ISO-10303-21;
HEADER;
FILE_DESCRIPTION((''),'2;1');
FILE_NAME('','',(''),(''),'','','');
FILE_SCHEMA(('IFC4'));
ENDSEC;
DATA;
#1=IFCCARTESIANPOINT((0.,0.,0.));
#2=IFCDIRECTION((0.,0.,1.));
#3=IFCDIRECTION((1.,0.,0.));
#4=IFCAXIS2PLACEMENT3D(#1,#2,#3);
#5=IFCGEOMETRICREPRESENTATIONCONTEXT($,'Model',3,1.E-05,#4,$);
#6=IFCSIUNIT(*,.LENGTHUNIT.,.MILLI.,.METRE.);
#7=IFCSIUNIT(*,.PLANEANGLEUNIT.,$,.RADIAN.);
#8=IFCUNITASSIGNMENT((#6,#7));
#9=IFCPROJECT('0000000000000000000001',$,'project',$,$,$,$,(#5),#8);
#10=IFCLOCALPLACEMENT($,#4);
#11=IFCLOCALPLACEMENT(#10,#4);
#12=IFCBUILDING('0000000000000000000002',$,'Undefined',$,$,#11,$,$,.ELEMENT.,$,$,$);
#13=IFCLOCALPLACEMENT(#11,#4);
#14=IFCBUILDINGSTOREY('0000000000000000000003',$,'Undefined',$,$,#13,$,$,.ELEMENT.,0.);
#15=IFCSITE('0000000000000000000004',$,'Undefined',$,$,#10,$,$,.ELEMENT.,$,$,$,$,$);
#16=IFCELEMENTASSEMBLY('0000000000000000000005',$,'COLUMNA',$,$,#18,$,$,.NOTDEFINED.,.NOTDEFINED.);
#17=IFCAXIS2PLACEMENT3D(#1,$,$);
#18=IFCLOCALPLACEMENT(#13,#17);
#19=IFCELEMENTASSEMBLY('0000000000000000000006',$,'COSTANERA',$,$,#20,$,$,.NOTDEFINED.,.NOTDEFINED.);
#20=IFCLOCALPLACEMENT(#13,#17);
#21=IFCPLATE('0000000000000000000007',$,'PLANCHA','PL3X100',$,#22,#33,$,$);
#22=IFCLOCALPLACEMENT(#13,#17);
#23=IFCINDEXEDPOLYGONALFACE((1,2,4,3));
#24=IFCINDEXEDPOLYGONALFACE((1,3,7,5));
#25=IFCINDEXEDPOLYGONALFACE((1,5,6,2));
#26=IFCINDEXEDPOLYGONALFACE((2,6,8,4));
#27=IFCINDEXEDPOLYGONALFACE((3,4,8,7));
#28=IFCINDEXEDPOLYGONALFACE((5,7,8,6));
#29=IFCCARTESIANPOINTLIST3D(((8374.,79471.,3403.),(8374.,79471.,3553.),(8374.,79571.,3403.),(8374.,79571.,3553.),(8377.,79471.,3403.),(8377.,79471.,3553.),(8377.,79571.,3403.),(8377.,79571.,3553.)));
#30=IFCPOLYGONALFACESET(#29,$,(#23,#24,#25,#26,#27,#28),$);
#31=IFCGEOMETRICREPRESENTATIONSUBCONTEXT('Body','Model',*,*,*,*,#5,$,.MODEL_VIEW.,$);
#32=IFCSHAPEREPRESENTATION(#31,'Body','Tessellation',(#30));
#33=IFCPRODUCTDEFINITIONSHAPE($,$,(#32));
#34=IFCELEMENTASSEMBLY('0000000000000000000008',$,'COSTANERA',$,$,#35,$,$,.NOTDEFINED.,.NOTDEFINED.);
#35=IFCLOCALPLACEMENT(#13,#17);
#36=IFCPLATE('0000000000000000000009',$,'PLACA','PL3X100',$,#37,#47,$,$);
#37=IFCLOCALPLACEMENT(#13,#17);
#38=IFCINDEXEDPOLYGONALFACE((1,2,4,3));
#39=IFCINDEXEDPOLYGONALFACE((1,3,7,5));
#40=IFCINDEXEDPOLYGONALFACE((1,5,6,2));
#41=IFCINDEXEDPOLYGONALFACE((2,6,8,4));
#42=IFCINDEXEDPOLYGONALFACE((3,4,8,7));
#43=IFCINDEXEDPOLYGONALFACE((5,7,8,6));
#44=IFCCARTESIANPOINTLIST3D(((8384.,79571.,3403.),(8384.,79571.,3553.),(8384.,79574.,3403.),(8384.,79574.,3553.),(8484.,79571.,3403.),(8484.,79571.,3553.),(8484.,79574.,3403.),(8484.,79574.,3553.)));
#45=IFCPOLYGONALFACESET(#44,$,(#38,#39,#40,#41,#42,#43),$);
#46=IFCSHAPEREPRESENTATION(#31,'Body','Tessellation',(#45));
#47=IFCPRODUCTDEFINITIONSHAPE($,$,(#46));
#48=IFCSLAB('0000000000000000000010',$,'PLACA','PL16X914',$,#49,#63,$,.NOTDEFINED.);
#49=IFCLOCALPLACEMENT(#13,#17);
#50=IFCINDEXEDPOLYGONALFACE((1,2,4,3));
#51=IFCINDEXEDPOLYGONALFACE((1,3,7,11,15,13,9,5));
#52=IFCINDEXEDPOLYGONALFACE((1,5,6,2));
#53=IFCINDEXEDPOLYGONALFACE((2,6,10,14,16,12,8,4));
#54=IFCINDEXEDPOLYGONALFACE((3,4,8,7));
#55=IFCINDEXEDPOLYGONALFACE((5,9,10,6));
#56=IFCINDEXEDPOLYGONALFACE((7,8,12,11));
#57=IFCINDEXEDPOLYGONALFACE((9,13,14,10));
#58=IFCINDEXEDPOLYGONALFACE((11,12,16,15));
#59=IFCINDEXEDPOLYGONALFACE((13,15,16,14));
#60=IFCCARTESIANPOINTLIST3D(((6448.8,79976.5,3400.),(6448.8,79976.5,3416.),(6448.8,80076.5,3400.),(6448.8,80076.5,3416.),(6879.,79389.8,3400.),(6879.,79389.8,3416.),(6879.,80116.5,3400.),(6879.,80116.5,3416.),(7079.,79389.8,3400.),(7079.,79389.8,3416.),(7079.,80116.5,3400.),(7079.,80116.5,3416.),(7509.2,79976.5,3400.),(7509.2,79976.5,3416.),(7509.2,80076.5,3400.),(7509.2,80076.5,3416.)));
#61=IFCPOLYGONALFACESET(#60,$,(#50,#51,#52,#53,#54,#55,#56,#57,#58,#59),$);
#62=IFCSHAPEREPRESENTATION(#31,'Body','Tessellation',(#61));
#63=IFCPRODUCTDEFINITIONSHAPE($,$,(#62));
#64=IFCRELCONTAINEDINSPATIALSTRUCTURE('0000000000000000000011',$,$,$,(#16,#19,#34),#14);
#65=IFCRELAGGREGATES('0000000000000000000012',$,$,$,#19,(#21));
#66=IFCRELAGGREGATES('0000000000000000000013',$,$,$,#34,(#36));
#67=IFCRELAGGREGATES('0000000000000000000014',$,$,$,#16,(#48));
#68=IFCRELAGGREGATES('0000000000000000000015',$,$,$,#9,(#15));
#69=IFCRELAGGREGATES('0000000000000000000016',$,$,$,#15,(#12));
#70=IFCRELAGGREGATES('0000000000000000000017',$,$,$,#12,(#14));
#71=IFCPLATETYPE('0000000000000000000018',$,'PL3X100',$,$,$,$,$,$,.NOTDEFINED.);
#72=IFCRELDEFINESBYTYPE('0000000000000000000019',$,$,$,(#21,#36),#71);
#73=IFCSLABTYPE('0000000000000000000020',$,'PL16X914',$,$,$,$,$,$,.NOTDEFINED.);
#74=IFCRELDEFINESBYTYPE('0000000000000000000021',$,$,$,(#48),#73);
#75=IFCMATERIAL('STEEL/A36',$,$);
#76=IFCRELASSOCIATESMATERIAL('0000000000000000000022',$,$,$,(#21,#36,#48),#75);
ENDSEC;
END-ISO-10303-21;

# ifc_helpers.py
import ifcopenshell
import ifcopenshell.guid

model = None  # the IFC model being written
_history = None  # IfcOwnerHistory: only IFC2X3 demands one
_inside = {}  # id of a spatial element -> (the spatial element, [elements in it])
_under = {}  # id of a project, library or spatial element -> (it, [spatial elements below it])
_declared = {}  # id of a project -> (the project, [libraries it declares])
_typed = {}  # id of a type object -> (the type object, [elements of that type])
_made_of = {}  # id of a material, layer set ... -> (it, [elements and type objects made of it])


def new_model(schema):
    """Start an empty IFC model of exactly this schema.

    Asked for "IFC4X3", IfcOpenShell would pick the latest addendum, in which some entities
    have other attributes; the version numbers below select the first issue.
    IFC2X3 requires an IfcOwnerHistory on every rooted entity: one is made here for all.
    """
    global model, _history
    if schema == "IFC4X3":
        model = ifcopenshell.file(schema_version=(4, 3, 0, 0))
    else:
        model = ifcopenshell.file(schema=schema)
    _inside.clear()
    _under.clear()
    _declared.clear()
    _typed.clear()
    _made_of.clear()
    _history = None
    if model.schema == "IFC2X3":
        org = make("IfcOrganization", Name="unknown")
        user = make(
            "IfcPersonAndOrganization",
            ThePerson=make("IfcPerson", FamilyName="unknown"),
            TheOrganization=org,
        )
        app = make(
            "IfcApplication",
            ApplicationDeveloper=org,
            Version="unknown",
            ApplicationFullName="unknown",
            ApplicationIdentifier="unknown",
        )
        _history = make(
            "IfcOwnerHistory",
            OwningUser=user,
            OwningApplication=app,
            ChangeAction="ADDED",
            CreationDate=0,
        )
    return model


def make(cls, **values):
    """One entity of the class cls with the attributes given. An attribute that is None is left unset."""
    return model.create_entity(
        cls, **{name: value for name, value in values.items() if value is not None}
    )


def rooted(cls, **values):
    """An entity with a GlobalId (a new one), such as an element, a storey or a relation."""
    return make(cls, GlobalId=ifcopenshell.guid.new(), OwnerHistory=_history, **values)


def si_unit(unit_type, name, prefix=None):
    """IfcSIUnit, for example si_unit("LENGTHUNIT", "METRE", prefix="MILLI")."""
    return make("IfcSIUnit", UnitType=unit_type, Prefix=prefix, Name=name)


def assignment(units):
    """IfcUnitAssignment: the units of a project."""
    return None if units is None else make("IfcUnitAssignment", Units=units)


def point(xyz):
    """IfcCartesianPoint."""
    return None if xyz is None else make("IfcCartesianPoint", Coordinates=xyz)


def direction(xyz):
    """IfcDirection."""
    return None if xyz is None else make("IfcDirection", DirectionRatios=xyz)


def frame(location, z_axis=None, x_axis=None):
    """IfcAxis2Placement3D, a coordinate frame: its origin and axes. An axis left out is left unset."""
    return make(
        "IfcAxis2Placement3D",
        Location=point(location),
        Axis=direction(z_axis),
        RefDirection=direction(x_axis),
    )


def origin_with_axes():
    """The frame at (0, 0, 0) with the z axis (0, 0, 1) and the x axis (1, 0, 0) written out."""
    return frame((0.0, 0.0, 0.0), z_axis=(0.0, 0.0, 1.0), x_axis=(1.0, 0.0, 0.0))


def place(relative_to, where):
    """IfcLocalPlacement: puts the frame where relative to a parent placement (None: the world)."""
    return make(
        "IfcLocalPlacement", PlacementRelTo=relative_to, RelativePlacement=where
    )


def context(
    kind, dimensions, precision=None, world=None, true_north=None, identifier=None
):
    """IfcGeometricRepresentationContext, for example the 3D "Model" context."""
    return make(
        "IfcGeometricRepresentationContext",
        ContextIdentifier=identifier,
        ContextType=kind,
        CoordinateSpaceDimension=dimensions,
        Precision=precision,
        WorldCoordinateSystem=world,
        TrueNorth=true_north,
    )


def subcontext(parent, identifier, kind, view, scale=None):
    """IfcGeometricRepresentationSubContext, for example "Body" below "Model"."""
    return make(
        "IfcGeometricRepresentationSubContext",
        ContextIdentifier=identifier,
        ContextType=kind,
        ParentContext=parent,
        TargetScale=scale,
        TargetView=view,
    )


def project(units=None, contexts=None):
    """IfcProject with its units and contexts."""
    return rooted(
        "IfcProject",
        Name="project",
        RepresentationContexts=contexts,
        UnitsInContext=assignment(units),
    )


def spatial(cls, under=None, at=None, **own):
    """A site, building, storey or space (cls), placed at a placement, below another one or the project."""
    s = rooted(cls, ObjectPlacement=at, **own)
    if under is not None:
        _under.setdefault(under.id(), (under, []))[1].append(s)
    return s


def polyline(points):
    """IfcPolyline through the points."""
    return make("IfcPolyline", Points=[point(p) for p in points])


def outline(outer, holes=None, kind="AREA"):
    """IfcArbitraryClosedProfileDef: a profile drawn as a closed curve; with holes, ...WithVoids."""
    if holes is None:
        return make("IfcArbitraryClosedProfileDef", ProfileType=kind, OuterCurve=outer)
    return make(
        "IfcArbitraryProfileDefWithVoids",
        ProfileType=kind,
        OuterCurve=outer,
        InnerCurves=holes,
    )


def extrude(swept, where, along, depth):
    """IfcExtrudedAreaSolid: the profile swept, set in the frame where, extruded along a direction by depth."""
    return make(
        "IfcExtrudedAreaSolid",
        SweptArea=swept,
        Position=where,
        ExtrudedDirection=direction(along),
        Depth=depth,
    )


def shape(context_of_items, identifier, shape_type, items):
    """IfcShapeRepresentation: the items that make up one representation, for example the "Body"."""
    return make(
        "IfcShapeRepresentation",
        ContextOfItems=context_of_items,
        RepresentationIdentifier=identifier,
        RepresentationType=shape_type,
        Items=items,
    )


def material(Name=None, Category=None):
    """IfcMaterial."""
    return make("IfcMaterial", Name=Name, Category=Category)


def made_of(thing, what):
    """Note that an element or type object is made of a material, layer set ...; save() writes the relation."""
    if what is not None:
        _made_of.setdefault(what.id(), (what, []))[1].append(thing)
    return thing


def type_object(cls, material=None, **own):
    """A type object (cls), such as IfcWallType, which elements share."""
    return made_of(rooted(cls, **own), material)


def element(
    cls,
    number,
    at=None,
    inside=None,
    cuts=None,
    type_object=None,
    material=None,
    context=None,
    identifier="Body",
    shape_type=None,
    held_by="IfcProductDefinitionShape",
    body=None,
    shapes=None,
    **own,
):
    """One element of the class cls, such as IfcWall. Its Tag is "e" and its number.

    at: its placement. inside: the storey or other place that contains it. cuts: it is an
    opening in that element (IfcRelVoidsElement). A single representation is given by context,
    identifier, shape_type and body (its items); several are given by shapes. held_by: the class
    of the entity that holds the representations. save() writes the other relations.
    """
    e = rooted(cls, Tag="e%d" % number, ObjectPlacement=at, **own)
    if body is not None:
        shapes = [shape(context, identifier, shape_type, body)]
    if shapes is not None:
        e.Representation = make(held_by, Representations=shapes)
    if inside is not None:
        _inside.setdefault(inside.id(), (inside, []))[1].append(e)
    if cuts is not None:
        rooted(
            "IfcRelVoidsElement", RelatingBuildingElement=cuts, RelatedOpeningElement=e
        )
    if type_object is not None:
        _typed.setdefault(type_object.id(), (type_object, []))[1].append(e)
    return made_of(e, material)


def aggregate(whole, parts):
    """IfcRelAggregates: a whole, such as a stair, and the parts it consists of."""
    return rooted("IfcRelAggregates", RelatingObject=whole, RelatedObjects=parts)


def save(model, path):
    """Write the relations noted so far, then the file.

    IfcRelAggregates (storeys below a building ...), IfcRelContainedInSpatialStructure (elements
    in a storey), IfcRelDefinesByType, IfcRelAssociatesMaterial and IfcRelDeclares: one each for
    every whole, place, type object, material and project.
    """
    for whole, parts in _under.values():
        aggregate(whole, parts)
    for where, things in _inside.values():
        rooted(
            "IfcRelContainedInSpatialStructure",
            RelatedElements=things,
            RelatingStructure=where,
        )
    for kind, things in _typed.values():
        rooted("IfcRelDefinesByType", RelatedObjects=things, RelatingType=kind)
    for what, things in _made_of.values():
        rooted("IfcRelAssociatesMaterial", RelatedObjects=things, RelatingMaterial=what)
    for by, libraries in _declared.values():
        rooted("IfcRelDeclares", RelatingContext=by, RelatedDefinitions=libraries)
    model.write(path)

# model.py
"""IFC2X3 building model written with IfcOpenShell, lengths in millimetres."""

from ifc_helpers import new_model, si_unit, frame, origin_with_axes, place, context, subcontext, project, spatial, polyline, outline, extrude, material, type_object, element, aggregate, save


model = new_model("IFC2X3")

# Units and contexts
model_context = context("Model", 3, precision=1e-05, world=origin_with_axes())
body_context = subcontext(model_context, "Body", "Model", "MODEL_VIEW")
ifc_project = project(units=[si_unit("LENGTHUNIT", "METRE", prefix="MILLI"), si_unit("PLANEANGLEUNIT", "RADIAN")], contexts=[model_context])

# Site, building, storey
site_placement = place(None, origin_with_axes())
site = spatial("IfcSite", under=ifc_project, at=site_placement, Name="Undefined", CompositionType="ELEMENT")
building_placement = place(site_placement, origin_with_axes())
building = spatial("IfcBuilding", under=site, at=building_placement, Name="Undefined", CompositionType="ELEMENT")
storey_placement = place(building_placement, origin_with_axes())
storey = spatial("IfcBuildingStorey", under=building, at=storey_placement, Name="Undefined", CompositionType="ELEMENT", Elevation=0.0)

# Shared definitions
ifc_material_1 = material(Name="STEEL/A36")

# Element assembly
assembly_1_placement = place(storey_placement, origin_with_axes())
assembly_1 = element("IfcElementAssembly", 1, at=assembly_1_placement, inside=storey, Name="COLUMNA", AssemblyPlace="NOTDEFINED", PredefinedType="NOTDEFINED")

# Element assemblies, plates
plate_type_1 = type_object("IfcPlateType", Name="PL3X100", PredefinedType="NOTDEFINED")
assembly_2_placement = place(storey_placement, origin_with_axes())
assembly_2 = element("IfcElementAssembly", 2, at=assembly_2_placement, inside=storey, Name="COSTANERA", AssemblyPlace="NOTDEFINED", PredefinedType="NOTDEFINED")
plate_1_placement = place(assembly_2_placement, frame((8375.5, 79571.0, 3403.0), z_axis=(-1.0, 0.0, 0.0), x_axis=(0.0, -1.0, 0.0)))
plate_1 = element("IfcPlate", 3, at=plate_1_placement, type_object=plate_type_1, material=ifc_material_1, Name="PLANCHA", Description="PL3X100", context=body_context, shape_type="SweptSolid", body=[
    extrude(outline(polyline([(0.0, 0.0), (100.0, 0.0), (100.0, 150.0), (0.0, 150.0), (0.0, 0.0)])), frame((0.0, 0.0, -1.5), z_axis=(0.0, 0.0, 1.0), x_axis=(1.0, 0.0, 0.0)), (0.0, 0.0, 1.0), 3.0),
])
aggregate(assembly_2, [plate_1])
assembly_3_placement = place(storey_placement, origin_with_axes())
assembly_3 = element("IfcElementAssembly", 4, at=assembly_3_placement, inside=storey, Name="COSTANERA", AssemblyPlace="NOTDEFINED", PredefinedType="NOTDEFINED")
plate_2_placement = place(assembly_3_placement, frame((8384.0, 79572.5, 3403.0), z_axis=(0.0, -1.0, 0.0), x_axis=(1.0, 0.0, 0.0)))
plate_2 = element("IfcPlate", 5, at=plate_2_placement, type_object=plate_type_1, material=ifc_material_1, Name="PLACA", Description="PL3X100", context=body_context, shape_type="SweptSolid", body=[
    extrude(outline(polyline([(0.0, 0.0), (100.0, 0.0), (100.0, 150.0), (0.0, 150.0), (0.0, 0.0)])), frame((0.0, 0.0, -1.5), z_axis=(0.0, 0.0, 1.0), x_axis=(1.0, 0.0, 0.0)), (0.0, 0.0, 1.0), 3.0),
])
aggregate(assembly_3, [plate_2])

# Slab
slab_type = type_object("IfcSlabType", Name="PL16X914", PredefinedType="NOTDEFINED")
slab_placement = place(assembly_1_placement, frame((7079.0, 79389.8, 3408.0), z_axis=(0.0, 0.0, 1.0), x_axis=(0.591328, 0.806431, 0.0)))
slab = element("IfcSlab", 6, at=slab_placement, type_object=slab_type, material=ifc_material_1, Name="PLACA", Description="PL16X914", PredefinedType="NOTDEFINED", context=body_context, shape_type="SweptSolid", body=[
    extrude(outline(polyline([(0.0, 0.0), (727.6, 0.0), (808.2, 59.1), (586.1, 429.7), (467.8, 591.0), (181.1, 914.3), (100.5, 855.2), (-118.3, 161.3), (0.0, 0.0)])), frame((0.0, 0.0, -8.0), z_axis=(0.0, 0.0, 1.0), x_axis=(1.0, 0.0, 0.0)), (0.0, 0.0, 1.0), 16.0),
])
aggregate(assembly_1, [slab])

save(model, "model.ifc")
